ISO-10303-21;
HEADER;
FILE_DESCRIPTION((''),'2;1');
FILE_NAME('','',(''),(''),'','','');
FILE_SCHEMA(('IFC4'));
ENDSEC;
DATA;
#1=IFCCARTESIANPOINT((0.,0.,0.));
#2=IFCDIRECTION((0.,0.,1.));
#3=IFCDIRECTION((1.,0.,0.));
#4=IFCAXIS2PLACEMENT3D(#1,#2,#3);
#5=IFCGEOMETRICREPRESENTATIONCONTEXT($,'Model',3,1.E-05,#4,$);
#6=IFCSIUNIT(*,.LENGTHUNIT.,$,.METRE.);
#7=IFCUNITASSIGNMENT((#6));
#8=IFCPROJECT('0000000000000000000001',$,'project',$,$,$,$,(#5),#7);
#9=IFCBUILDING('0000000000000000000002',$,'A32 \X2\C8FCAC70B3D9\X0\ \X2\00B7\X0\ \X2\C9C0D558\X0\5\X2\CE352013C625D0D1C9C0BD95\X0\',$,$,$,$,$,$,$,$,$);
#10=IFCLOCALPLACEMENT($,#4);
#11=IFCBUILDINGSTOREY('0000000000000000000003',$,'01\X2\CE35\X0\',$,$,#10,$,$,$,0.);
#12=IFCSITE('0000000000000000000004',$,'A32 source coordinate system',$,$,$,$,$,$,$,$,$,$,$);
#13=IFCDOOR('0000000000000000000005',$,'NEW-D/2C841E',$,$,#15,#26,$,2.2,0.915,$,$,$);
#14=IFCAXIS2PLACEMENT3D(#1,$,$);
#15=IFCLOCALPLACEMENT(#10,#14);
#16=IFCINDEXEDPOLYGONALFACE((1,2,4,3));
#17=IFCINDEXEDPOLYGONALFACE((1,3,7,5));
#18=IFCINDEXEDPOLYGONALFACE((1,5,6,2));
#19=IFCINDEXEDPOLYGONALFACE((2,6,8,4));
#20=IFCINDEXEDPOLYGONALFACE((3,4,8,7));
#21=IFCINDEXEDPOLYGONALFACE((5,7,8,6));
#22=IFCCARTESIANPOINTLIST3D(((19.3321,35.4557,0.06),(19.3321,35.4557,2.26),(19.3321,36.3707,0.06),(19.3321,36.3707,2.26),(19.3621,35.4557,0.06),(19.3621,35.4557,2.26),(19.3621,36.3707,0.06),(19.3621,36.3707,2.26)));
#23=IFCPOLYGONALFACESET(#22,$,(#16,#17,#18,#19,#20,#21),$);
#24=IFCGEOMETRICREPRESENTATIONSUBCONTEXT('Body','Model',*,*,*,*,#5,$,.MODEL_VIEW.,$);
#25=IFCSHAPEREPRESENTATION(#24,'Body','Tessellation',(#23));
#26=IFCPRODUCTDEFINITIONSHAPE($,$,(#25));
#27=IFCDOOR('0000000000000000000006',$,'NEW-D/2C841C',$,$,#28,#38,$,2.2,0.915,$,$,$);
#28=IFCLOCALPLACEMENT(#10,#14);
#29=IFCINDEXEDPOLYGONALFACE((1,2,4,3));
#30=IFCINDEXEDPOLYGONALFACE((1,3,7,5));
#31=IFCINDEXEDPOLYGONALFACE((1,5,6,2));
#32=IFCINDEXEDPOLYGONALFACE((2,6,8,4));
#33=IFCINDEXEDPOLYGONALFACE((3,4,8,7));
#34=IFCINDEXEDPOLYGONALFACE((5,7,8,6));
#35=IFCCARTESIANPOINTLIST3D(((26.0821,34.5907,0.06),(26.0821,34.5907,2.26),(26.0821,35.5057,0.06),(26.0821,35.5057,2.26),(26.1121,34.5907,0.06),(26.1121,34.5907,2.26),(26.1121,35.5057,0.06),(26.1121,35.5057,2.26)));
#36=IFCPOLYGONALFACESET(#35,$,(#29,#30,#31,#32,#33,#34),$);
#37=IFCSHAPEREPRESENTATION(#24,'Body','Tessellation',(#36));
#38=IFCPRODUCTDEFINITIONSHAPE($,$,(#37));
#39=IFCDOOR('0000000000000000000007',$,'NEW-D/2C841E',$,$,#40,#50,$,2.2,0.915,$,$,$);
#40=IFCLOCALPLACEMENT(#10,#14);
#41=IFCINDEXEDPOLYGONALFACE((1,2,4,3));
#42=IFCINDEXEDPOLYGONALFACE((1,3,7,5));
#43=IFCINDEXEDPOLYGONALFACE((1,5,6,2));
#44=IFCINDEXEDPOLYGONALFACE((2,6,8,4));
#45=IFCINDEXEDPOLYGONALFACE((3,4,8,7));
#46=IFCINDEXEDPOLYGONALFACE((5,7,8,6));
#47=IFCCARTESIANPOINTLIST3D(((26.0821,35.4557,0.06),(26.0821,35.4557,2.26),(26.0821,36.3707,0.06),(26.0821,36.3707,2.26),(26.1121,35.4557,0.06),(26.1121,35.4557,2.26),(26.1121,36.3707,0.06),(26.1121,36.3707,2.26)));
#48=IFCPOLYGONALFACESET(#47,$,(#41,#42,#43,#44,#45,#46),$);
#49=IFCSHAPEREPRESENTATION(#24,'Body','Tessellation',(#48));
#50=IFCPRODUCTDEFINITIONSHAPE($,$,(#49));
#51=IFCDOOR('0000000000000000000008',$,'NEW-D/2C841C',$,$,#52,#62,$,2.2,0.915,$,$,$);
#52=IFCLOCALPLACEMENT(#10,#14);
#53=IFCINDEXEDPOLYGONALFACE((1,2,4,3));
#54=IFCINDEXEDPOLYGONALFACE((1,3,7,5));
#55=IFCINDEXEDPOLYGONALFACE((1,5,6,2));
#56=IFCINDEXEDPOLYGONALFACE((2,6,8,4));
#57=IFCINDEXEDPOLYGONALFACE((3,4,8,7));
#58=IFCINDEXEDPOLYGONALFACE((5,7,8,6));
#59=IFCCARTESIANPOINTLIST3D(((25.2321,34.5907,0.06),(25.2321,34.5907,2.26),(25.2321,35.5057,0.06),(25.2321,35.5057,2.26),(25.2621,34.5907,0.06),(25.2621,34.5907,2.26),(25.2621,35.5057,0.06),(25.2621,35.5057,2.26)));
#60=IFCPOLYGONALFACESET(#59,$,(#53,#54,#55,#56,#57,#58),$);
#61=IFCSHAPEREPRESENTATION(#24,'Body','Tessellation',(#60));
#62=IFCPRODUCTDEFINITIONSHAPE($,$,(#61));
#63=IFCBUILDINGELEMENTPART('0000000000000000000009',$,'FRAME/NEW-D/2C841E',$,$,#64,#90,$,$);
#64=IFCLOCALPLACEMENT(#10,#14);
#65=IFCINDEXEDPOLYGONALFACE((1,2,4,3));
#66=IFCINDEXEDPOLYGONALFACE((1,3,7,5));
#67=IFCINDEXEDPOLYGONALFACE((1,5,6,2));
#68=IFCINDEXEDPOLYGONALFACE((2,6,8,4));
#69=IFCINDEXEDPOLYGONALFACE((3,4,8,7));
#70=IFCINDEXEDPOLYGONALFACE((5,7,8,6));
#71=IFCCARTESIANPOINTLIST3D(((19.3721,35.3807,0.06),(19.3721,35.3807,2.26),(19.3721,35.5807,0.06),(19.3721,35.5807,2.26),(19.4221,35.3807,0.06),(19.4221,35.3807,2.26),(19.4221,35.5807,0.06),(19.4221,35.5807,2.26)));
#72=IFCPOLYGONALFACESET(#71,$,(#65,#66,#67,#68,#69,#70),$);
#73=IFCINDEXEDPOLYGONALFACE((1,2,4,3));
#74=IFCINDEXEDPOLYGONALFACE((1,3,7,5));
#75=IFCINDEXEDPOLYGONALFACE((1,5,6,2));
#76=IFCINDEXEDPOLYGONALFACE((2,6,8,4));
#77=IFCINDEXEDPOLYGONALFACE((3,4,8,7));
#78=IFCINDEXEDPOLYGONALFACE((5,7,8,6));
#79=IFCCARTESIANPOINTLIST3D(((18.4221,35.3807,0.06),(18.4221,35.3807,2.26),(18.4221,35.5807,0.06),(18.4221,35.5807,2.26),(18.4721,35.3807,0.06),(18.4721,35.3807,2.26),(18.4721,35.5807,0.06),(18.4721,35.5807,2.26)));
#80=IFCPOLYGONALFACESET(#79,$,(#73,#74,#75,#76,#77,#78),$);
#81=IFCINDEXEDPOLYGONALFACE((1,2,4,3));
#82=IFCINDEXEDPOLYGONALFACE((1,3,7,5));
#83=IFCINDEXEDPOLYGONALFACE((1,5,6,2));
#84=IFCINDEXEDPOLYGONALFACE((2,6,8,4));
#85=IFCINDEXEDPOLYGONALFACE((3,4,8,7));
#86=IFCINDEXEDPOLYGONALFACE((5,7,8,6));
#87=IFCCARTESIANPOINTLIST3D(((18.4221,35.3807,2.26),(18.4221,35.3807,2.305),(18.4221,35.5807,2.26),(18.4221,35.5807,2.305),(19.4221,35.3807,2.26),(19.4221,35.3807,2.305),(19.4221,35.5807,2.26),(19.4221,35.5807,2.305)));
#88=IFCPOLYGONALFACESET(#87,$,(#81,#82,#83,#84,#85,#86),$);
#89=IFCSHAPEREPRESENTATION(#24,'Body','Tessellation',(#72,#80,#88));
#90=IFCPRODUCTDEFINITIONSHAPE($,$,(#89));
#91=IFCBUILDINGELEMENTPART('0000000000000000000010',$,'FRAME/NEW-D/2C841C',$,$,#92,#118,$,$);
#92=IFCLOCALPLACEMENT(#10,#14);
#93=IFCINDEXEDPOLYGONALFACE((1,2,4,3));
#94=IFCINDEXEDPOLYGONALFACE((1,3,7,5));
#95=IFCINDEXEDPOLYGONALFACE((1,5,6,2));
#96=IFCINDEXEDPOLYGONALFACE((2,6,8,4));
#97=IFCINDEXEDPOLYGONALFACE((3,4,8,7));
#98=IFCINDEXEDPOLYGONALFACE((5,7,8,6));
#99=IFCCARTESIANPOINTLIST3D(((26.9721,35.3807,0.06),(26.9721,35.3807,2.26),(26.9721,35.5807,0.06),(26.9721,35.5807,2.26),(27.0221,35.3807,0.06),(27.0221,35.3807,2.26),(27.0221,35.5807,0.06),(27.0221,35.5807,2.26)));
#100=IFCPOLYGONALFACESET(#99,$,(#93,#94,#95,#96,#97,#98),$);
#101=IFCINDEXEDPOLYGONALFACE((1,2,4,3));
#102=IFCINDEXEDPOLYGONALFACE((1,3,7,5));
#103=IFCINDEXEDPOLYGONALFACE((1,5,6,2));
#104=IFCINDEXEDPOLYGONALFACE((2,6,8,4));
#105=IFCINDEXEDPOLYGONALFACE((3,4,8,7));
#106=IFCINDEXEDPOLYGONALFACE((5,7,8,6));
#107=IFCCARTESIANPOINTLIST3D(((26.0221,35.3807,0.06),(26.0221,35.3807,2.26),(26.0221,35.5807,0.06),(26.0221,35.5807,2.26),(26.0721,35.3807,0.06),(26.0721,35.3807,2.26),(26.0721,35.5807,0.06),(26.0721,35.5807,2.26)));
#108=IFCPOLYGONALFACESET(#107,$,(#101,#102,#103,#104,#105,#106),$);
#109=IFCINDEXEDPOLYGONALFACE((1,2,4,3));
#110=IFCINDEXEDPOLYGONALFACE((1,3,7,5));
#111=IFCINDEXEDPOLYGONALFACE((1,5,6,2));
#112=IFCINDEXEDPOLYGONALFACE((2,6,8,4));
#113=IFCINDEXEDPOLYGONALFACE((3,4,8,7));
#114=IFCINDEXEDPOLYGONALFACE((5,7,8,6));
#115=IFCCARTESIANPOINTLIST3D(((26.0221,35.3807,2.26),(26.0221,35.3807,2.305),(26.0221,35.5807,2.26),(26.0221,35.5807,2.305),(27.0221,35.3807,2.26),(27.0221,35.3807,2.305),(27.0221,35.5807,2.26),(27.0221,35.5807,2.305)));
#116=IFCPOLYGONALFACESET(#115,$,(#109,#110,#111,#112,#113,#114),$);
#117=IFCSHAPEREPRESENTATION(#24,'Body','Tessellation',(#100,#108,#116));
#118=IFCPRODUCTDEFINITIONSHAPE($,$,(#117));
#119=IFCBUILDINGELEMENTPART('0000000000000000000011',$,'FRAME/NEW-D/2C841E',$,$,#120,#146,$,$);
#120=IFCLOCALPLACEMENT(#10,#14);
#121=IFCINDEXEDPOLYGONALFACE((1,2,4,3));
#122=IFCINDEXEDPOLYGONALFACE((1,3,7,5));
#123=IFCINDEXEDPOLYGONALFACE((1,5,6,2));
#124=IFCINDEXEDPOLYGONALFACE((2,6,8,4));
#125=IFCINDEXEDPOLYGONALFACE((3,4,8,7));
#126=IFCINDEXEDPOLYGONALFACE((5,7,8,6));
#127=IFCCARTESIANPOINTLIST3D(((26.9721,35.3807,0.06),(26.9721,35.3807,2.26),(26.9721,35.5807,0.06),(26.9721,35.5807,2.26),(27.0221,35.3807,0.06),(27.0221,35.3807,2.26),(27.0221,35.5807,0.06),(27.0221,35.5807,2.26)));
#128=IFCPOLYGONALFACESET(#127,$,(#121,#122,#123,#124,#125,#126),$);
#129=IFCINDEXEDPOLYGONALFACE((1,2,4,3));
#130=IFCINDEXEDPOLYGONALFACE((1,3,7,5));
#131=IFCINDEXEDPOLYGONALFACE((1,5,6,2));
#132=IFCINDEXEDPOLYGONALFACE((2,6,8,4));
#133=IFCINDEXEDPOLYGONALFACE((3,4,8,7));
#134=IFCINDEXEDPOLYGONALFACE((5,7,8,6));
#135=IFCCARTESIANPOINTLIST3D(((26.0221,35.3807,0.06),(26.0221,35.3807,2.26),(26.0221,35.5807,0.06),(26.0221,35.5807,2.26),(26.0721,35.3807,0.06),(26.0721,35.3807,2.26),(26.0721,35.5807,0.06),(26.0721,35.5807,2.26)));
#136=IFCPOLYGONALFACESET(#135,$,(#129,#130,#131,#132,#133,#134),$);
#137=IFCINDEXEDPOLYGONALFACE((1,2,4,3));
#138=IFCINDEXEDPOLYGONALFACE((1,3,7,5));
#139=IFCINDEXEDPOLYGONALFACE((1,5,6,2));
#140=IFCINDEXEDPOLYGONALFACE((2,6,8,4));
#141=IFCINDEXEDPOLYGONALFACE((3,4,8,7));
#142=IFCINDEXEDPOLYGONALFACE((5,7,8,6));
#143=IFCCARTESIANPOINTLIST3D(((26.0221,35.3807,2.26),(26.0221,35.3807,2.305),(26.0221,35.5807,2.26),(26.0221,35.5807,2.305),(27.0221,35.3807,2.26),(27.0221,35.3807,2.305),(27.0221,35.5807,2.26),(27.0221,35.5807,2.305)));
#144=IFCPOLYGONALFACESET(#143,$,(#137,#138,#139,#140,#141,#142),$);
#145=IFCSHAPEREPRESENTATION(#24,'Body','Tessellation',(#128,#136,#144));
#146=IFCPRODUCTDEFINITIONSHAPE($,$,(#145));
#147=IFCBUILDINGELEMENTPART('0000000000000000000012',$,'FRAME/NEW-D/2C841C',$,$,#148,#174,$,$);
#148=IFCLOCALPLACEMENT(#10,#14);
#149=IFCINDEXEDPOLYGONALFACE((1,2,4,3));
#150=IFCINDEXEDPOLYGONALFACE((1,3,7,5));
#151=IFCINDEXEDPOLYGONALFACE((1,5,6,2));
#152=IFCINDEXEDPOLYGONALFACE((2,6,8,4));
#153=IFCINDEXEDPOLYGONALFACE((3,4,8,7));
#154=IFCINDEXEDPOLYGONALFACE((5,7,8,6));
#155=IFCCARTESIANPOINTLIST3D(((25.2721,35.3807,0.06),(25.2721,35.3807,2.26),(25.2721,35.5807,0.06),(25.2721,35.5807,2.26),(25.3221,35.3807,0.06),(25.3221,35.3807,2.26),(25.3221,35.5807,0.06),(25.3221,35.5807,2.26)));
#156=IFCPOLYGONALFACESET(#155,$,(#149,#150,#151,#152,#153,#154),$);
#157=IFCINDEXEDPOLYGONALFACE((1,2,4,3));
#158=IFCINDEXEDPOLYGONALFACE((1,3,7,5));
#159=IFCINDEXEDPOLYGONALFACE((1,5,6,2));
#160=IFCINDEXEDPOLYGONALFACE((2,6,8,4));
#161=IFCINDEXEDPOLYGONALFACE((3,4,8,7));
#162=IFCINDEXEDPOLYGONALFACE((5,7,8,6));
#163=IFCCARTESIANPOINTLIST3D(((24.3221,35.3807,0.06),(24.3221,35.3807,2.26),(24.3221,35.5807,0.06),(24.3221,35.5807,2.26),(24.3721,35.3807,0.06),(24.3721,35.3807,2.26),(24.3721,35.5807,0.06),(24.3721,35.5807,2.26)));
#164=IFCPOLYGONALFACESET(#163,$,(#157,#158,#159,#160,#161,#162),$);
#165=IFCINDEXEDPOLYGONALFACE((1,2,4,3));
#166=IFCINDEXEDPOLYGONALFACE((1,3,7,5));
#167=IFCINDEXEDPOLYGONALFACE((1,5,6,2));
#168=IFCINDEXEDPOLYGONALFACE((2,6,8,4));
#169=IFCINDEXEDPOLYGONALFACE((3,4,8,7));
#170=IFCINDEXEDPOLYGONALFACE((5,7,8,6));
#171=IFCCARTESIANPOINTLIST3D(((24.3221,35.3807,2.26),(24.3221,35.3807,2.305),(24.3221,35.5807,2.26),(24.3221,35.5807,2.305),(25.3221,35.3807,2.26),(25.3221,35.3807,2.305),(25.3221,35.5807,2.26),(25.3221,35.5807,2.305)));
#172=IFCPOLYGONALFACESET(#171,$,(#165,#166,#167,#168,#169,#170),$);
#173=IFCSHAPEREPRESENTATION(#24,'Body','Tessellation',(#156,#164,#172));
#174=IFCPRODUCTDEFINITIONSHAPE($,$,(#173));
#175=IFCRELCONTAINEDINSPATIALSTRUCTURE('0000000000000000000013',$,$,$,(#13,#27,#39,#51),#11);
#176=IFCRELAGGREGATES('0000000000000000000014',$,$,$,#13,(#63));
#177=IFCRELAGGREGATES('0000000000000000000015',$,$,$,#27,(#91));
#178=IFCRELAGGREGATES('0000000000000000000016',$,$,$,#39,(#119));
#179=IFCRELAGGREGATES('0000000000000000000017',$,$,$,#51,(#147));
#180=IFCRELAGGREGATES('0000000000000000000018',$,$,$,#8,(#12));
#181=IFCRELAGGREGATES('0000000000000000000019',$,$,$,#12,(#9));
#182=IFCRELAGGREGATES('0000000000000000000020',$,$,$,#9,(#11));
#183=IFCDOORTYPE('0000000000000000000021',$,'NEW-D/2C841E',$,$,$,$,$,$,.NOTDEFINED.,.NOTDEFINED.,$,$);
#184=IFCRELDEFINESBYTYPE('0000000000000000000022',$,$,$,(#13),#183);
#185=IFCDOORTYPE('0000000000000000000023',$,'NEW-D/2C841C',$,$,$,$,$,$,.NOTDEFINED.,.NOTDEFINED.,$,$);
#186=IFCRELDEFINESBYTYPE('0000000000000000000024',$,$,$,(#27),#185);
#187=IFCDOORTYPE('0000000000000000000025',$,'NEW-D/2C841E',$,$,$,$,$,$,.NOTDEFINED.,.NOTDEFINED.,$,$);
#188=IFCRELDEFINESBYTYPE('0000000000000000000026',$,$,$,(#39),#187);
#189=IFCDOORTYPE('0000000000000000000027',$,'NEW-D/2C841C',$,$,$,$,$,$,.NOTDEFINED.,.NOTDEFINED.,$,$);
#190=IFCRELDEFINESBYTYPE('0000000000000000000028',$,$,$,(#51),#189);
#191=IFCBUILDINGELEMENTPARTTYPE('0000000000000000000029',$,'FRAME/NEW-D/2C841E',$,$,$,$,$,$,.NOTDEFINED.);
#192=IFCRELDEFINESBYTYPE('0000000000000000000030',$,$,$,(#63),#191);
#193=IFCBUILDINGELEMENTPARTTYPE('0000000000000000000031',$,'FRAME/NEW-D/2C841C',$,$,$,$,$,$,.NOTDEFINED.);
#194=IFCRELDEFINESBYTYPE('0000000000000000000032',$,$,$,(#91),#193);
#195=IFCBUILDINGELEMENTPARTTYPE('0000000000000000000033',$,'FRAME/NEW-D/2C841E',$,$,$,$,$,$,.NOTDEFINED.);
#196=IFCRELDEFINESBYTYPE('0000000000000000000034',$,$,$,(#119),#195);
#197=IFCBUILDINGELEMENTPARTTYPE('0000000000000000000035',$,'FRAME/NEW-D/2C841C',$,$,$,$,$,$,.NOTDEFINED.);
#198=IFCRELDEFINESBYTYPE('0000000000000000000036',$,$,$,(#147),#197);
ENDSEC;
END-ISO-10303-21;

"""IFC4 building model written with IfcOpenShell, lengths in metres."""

from ifc_helpers import new_model, si_unit, frame, origin, origin_with_axes, place, context, subcontext, project, spatial, polyline, outline, extrude, source, transform, mapped, type_object, type_shapes, element, aggregate, save


model = new_model("IFC4")

# Units and contexts
model_context = context("Model", 3, precision=1e-05, world=origin_with_axes())
body_context = subcontext(model_context, "Body", "Model", "MODEL_VIEW")
ifc_project = project(units=[si_unit("LENGTHUNIT", "METRE")], contexts=[model_context])

# Site, building, storey
site = spatial("IfcSite", under=ifc_project, Name="A32 source coordinate system")
building = spatial("IfcBuilding", under=site, Name="A32 주거동 · 지하5층–옥탑지붕")
storey_placement = place(None, origin_with_axes())
storey = spatial("IfcBuildingStorey", under=building, at=storey_placement, Name="01층", Elevation=0.0)

# Doors
door_type_1 = type_object("IfcDoorType", Name="NEW-D/2C841E", OperationType="NOTDEFINED", PredefinedType="NOTDEFINED")
shared_shape_1 = source(origin(), body_context, "Body", "SweptSolid", [
    extrude(outline(polyline([(19.3321, 35.4557), (19.3321, 36.3707), (19.3621, 36.3707), (19.3621, 35.4557), (19.3321, 35.4557)])), frame((0.0, 0.0, 0.06)), (0.0, 0.0, 1.0), 2.2),
])
type_shapes(door_type_1, [shared_shape_1])
door_1_placement = place(storey_placement, origin_with_axes())
door_1 = element("IfcDoor", 1, at=door_1_placement, inside=storey, type_object=door_type_1, Name="NEW-D/2C841E", OverallHeight=2.2, OverallWidth=0.915, context=body_context, shape_type="MappedRepresentation", body=[
    mapped(shared_shape_1, transform((0.0, 0.0, 0.0), scale=1.0)),
])
door_type_2 = type_object("IfcDoorType", Name="NEW-D/2C841C", OperationType="NOTDEFINED", PredefinedType="NOTDEFINED")
shared_shape_2 = source(origin(), body_context, "Body", "SweptSolid", [
    extrude(outline(polyline([(26.1121, 35.5057), (26.1121, 34.5907), (26.0821, 34.5907), (26.0821, 35.5057), (26.1121, 35.5057)])), frame((0.0, 0.0, 0.06)), (0.0, 0.0, 1.0), 2.2),
])
type_shapes(door_type_2, [shared_shape_2])
door_2_placement = place(storey_placement, origin_with_axes())
door_2 = element("IfcDoor", 2, at=door_2_placement, inside=storey, type_object=door_type_2, Name="NEW-D/2C841C", OverallHeight=2.2, OverallWidth=0.915, context=body_context, shape_type="MappedRepresentation", body=[
    mapped(shared_shape_2, transform((0.0, 0.0, 0.0), scale=1.0)),
])
door_type_3 = type_object("IfcDoorType", Name="NEW-D/2C841E", OperationType="NOTDEFINED", PredefinedType="NOTDEFINED")
shared_shape_3 = source(origin(), body_context, "Body", "SweptSolid", [
    extrude(outline(polyline([(26.0821, 36.3707), (26.1121, 36.3707), (26.1121, 35.4557), (26.0821, 35.4557), (26.0821, 36.3707)])), frame((0.0, 0.0, 0.06)), (0.0, 0.0, 1.0), 2.2),
])
type_shapes(door_type_3, [shared_shape_3])
door_3_placement = place(storey_placement, origin_with_axes())
door_3 = element("IfcDoor", 3, at=door_3_placement, inside=storey, type_object=door_type_3, Name="NEW-D/2C841E", OverallHeight=2.2, OverallWidth=0.915, context=body_context, shape_type="MappedRepresentation", body=[
    mapped(shared_shape_3, transform((0.0, 0.0, 0.0), scale=1.0)),
])
door_type_4 = type_object("IfcDoorType", Name="NEW-D/2C841C", OperationType="NOTDEFINED", PredefinedType="NOTDEFINED")
shared_shape_4 = source(origin(), body_context, "Body", "SweptSolid", [
    extrude(outline(polyline([(25.2621, 34.5907), (25.2321, 34.5907), (25.2321, 35.5057), (25.2621, 35.5057), (25.2621, 34.5907)])), frame((0.0, 0.0, 0.06)), (0.0, 0.0, 1.0), 2.2),
])
type_shapes(door_type_4, [shared_shape_4])
door_4_placement = place(storey_placement, origin_with_axes())
door_4 = element("IfcDoor", 4, at=door_4_placement, inside=storey, type_object=door_type_4, Name="NEW-D/2C841C", OverallHeight=2.2, OverallWidth=0.915, context=body_context, shape_type="MappedRepresentation", body=[
    mapped(shared_shape_4, transform((0.0, 0.0, 0.0), scale=1.0)),
])

# Building element parts
building_element_part_type_1 = type_object("IfcBuildingElementPartType", Name="FRAME/NEW-D/2C841E", PredefinedType="NOTDEFINED")
shared_shape_5 = source(origin(), body_context, "Body", "SweptSolid", [
    extrude(outline(polyline([(19.3721, 35.5807), (19.4221, 35.5807), (19.4221, 35.3807), (19.3721, 35.3807), (19.3721, 35.5807)])), frame((0.0, 0.0, 0.06)), (0.0, 0.0, 1.0), 2.2),
    extrude(outline(polyline([(18.4221, 35.5807), (18.4721, 35.5807), (18.4721, 35.3807), (18.4221, 35.3807), (18.4221, 35.5807)])), frame((0.0, 0.0, 0.06)), (0.0, 0.0, 1.0), 2.2),
    extrude(outline(polyline([(19.4221, 35.3807), (19.4221, 35.5807), (18.4221, 35.5807), (18.4221, 35.3807), (19.4221, 35.3807)])), frame((0.0, 0.0, 2.26)), (0.0, 0.0, 1.0), 0.045),
])
type_shapes(building_element_part_type_1, [shared_shape_5])
building_element_part_1_placement = place(door_1_placement, origin_with_axes())
building_element_part_1 = element("IfcBuildingElementPart", 5, at=building_element_part_1_placement, type_object=building_element_part_type_1, Name="FRAME/NEW-D/2C841E", context=body_context, shape_type="MappedRepresentation", body=[
    mapped(shared_shape_5, transform((0.0, 0.0, 0.0), scale=1.0)),
])
aggregate(door_1, [building_element_part_1])
building_element_part_type_2 = type_object("IfcBuildingElementPartType", Name="FRAME/NEW-D/2C841C", PredefinedType="NOTDEFINED")
shared_shape_6 = source(origin(), body_context, "Body", "SweptSolid", [
    extrude(outline(polyline([(27.0221, 35.5807), (27.0221, 35.3807), (26.9721, 35.3807), (26.9721, 35.5807), (27.0221, 35.5807)])), frame((0.0, 0.0, 0.06)), (0.0, 0.0, 1.0), 2.2),
    extrude(outline(polyline([(26.0721, 35.5807), (26.0721, 35.3807), (26.0221, 35.3807), (26.0221, 35.5807), (26.0721, 35.5807)])), frame((0.0, 0.0, 0.06)), (0.0, 0.0, 1.0), 2.2),
    extrude(outline(polyline([(27.0221, 35.3807), (27.0221, 35.5807), (26.0221, 35.5807), (26.0221, 35.3807), (27.0221, 35.3807)])), frame((0.0, 0.0, 2.26)), (0.0, 0.0, 1.0), 0.045),
])
type_shapes(building_element_part_type_2, [shared_shape_6])
building_element_part_2_placement = place(door_2_placement, origin_with_axes())
building_element_part_2 = element("IfcBuildingElementPart", 6, at=building_element_part_2_placement, type_object=building_element_part_type_2, Name="FRAME/NEW-D/2C841C", context=body_context, shape_type="MappedRepresentation", body=[
    mapped(shared_shape_6, transform((0.0, 0.0, 0.0), scale=1.0)),
])
aggregate(door_2, [building_element_part_2])
building_element_part_type_3 = type_object("IfcBuildingElementPartType", Name="FRAME/NEW-D/2C841E", PredefinedType="NOTDEFINED")
shared_shape_7 = source(origin(), body_context, "Body", "SweptSolid", [
    extrude(outline(polyline([(27.0221, 35.5807), (27.0221, 35.3807), (26.9721, 35.3807), (26.9721, 35.5807), (27.0221, 35.5807)])), frame((0.0, 0.0, 0.06)), (0.0, 0.0, 1.0), 2.2),
    extrude(outline(polyline([(26.0721, 35.5807), (26.0721, 35.3807), (26.0221, 35.3807), (26.0221, 35.5807), (26.0721, 35.5807)])), frame((0.0, 0.0, 0.06)), (0.0, 0.0, 1.0), 2.2),
    extrude(outline(polyline([(27.0221, 35.3807), (27.0221, 35.5807), (26.0221, 35.5807), (26.0221, 35.3807), (27.0221, 35.3807)])), frame((0.0, 0.0, 2.26)), (0.0, 0.0, 1.0), 0.045),
])
type_shapes(building_element_part_type_3, [shared_shape_7])
building_element_part_3_placement = place(door_3_placement, origin_with_axes())
building_element_part_3 = element("IfcBuildingElementPart", 7, at=building_element_part_3_placement, type_object=building_element_part_type_3, Name="FRAME/NEW-D/2C841E", context=body_context, shape_type="MappedRepresentation", body=[
    mapped(shared_shape_7, transform((0.0, 0.0, 0.0), scale=1.0)),
])
aggregate(door_3, [building_element_part_3])
building_element_part_type_4 = type_object("IfcBuildingElementPartType", Name="FRAME/NEW-D/2C841C", PredefinedType="NOTDEFINED")
shared_shape_8 = source(origin(), body_context, "Body", "SweptSolid", [
    extrude(outline(polyline([(25.2721, 35.5807), (25.3221, 35.5807), (25.3221, 35.3807), (25.2721, 35.3807), (25.2721, 35.5807)])), frame((0.0, 0.0, 0.06)), (0.0, 0.0, 1.0), 2.2),
    extrude(outline(polyline([(24.3221, 35.5807), (24.3721, 35.5807), (24.3721, 35.3807), (24.3221, 35.3807), (24.3221, 35.5807)])), frame((0.0, 0.0, 0.06)), (0.0, 0.0, 1.0), 2.2),
    extrude(outline(polyline([(25.3221, 35.3807), (25.3221, 35.5807), (24.3221, 35.5807), (24.3221, 35.3807), (25.3221, 35.3807)])), frame((0.0, 0.0, 2.26)), (0.0, 0.0, 1.0), 0.045),
])
type_shapes(building_element_part_type_4, [shared_shape_8])
building_element_part_4_placement = place(door_4_placement, origin_with_axes())
building_element_part_4 = element("IfcBuildingElementPart", 8, at=building_element_part_4_placement, type_object=building_element_part_type_4, Name="FRAME/NEW-D/2C841C", context=body_context, shape_type="MappedRepresentation", body=[
    mapped(shared_shape_8, transform((0.0, 0.0, 0.0), scale=1.0)),
])
aggregate(door_4, [building_element_part_4])

save(model, "model.ifc")
